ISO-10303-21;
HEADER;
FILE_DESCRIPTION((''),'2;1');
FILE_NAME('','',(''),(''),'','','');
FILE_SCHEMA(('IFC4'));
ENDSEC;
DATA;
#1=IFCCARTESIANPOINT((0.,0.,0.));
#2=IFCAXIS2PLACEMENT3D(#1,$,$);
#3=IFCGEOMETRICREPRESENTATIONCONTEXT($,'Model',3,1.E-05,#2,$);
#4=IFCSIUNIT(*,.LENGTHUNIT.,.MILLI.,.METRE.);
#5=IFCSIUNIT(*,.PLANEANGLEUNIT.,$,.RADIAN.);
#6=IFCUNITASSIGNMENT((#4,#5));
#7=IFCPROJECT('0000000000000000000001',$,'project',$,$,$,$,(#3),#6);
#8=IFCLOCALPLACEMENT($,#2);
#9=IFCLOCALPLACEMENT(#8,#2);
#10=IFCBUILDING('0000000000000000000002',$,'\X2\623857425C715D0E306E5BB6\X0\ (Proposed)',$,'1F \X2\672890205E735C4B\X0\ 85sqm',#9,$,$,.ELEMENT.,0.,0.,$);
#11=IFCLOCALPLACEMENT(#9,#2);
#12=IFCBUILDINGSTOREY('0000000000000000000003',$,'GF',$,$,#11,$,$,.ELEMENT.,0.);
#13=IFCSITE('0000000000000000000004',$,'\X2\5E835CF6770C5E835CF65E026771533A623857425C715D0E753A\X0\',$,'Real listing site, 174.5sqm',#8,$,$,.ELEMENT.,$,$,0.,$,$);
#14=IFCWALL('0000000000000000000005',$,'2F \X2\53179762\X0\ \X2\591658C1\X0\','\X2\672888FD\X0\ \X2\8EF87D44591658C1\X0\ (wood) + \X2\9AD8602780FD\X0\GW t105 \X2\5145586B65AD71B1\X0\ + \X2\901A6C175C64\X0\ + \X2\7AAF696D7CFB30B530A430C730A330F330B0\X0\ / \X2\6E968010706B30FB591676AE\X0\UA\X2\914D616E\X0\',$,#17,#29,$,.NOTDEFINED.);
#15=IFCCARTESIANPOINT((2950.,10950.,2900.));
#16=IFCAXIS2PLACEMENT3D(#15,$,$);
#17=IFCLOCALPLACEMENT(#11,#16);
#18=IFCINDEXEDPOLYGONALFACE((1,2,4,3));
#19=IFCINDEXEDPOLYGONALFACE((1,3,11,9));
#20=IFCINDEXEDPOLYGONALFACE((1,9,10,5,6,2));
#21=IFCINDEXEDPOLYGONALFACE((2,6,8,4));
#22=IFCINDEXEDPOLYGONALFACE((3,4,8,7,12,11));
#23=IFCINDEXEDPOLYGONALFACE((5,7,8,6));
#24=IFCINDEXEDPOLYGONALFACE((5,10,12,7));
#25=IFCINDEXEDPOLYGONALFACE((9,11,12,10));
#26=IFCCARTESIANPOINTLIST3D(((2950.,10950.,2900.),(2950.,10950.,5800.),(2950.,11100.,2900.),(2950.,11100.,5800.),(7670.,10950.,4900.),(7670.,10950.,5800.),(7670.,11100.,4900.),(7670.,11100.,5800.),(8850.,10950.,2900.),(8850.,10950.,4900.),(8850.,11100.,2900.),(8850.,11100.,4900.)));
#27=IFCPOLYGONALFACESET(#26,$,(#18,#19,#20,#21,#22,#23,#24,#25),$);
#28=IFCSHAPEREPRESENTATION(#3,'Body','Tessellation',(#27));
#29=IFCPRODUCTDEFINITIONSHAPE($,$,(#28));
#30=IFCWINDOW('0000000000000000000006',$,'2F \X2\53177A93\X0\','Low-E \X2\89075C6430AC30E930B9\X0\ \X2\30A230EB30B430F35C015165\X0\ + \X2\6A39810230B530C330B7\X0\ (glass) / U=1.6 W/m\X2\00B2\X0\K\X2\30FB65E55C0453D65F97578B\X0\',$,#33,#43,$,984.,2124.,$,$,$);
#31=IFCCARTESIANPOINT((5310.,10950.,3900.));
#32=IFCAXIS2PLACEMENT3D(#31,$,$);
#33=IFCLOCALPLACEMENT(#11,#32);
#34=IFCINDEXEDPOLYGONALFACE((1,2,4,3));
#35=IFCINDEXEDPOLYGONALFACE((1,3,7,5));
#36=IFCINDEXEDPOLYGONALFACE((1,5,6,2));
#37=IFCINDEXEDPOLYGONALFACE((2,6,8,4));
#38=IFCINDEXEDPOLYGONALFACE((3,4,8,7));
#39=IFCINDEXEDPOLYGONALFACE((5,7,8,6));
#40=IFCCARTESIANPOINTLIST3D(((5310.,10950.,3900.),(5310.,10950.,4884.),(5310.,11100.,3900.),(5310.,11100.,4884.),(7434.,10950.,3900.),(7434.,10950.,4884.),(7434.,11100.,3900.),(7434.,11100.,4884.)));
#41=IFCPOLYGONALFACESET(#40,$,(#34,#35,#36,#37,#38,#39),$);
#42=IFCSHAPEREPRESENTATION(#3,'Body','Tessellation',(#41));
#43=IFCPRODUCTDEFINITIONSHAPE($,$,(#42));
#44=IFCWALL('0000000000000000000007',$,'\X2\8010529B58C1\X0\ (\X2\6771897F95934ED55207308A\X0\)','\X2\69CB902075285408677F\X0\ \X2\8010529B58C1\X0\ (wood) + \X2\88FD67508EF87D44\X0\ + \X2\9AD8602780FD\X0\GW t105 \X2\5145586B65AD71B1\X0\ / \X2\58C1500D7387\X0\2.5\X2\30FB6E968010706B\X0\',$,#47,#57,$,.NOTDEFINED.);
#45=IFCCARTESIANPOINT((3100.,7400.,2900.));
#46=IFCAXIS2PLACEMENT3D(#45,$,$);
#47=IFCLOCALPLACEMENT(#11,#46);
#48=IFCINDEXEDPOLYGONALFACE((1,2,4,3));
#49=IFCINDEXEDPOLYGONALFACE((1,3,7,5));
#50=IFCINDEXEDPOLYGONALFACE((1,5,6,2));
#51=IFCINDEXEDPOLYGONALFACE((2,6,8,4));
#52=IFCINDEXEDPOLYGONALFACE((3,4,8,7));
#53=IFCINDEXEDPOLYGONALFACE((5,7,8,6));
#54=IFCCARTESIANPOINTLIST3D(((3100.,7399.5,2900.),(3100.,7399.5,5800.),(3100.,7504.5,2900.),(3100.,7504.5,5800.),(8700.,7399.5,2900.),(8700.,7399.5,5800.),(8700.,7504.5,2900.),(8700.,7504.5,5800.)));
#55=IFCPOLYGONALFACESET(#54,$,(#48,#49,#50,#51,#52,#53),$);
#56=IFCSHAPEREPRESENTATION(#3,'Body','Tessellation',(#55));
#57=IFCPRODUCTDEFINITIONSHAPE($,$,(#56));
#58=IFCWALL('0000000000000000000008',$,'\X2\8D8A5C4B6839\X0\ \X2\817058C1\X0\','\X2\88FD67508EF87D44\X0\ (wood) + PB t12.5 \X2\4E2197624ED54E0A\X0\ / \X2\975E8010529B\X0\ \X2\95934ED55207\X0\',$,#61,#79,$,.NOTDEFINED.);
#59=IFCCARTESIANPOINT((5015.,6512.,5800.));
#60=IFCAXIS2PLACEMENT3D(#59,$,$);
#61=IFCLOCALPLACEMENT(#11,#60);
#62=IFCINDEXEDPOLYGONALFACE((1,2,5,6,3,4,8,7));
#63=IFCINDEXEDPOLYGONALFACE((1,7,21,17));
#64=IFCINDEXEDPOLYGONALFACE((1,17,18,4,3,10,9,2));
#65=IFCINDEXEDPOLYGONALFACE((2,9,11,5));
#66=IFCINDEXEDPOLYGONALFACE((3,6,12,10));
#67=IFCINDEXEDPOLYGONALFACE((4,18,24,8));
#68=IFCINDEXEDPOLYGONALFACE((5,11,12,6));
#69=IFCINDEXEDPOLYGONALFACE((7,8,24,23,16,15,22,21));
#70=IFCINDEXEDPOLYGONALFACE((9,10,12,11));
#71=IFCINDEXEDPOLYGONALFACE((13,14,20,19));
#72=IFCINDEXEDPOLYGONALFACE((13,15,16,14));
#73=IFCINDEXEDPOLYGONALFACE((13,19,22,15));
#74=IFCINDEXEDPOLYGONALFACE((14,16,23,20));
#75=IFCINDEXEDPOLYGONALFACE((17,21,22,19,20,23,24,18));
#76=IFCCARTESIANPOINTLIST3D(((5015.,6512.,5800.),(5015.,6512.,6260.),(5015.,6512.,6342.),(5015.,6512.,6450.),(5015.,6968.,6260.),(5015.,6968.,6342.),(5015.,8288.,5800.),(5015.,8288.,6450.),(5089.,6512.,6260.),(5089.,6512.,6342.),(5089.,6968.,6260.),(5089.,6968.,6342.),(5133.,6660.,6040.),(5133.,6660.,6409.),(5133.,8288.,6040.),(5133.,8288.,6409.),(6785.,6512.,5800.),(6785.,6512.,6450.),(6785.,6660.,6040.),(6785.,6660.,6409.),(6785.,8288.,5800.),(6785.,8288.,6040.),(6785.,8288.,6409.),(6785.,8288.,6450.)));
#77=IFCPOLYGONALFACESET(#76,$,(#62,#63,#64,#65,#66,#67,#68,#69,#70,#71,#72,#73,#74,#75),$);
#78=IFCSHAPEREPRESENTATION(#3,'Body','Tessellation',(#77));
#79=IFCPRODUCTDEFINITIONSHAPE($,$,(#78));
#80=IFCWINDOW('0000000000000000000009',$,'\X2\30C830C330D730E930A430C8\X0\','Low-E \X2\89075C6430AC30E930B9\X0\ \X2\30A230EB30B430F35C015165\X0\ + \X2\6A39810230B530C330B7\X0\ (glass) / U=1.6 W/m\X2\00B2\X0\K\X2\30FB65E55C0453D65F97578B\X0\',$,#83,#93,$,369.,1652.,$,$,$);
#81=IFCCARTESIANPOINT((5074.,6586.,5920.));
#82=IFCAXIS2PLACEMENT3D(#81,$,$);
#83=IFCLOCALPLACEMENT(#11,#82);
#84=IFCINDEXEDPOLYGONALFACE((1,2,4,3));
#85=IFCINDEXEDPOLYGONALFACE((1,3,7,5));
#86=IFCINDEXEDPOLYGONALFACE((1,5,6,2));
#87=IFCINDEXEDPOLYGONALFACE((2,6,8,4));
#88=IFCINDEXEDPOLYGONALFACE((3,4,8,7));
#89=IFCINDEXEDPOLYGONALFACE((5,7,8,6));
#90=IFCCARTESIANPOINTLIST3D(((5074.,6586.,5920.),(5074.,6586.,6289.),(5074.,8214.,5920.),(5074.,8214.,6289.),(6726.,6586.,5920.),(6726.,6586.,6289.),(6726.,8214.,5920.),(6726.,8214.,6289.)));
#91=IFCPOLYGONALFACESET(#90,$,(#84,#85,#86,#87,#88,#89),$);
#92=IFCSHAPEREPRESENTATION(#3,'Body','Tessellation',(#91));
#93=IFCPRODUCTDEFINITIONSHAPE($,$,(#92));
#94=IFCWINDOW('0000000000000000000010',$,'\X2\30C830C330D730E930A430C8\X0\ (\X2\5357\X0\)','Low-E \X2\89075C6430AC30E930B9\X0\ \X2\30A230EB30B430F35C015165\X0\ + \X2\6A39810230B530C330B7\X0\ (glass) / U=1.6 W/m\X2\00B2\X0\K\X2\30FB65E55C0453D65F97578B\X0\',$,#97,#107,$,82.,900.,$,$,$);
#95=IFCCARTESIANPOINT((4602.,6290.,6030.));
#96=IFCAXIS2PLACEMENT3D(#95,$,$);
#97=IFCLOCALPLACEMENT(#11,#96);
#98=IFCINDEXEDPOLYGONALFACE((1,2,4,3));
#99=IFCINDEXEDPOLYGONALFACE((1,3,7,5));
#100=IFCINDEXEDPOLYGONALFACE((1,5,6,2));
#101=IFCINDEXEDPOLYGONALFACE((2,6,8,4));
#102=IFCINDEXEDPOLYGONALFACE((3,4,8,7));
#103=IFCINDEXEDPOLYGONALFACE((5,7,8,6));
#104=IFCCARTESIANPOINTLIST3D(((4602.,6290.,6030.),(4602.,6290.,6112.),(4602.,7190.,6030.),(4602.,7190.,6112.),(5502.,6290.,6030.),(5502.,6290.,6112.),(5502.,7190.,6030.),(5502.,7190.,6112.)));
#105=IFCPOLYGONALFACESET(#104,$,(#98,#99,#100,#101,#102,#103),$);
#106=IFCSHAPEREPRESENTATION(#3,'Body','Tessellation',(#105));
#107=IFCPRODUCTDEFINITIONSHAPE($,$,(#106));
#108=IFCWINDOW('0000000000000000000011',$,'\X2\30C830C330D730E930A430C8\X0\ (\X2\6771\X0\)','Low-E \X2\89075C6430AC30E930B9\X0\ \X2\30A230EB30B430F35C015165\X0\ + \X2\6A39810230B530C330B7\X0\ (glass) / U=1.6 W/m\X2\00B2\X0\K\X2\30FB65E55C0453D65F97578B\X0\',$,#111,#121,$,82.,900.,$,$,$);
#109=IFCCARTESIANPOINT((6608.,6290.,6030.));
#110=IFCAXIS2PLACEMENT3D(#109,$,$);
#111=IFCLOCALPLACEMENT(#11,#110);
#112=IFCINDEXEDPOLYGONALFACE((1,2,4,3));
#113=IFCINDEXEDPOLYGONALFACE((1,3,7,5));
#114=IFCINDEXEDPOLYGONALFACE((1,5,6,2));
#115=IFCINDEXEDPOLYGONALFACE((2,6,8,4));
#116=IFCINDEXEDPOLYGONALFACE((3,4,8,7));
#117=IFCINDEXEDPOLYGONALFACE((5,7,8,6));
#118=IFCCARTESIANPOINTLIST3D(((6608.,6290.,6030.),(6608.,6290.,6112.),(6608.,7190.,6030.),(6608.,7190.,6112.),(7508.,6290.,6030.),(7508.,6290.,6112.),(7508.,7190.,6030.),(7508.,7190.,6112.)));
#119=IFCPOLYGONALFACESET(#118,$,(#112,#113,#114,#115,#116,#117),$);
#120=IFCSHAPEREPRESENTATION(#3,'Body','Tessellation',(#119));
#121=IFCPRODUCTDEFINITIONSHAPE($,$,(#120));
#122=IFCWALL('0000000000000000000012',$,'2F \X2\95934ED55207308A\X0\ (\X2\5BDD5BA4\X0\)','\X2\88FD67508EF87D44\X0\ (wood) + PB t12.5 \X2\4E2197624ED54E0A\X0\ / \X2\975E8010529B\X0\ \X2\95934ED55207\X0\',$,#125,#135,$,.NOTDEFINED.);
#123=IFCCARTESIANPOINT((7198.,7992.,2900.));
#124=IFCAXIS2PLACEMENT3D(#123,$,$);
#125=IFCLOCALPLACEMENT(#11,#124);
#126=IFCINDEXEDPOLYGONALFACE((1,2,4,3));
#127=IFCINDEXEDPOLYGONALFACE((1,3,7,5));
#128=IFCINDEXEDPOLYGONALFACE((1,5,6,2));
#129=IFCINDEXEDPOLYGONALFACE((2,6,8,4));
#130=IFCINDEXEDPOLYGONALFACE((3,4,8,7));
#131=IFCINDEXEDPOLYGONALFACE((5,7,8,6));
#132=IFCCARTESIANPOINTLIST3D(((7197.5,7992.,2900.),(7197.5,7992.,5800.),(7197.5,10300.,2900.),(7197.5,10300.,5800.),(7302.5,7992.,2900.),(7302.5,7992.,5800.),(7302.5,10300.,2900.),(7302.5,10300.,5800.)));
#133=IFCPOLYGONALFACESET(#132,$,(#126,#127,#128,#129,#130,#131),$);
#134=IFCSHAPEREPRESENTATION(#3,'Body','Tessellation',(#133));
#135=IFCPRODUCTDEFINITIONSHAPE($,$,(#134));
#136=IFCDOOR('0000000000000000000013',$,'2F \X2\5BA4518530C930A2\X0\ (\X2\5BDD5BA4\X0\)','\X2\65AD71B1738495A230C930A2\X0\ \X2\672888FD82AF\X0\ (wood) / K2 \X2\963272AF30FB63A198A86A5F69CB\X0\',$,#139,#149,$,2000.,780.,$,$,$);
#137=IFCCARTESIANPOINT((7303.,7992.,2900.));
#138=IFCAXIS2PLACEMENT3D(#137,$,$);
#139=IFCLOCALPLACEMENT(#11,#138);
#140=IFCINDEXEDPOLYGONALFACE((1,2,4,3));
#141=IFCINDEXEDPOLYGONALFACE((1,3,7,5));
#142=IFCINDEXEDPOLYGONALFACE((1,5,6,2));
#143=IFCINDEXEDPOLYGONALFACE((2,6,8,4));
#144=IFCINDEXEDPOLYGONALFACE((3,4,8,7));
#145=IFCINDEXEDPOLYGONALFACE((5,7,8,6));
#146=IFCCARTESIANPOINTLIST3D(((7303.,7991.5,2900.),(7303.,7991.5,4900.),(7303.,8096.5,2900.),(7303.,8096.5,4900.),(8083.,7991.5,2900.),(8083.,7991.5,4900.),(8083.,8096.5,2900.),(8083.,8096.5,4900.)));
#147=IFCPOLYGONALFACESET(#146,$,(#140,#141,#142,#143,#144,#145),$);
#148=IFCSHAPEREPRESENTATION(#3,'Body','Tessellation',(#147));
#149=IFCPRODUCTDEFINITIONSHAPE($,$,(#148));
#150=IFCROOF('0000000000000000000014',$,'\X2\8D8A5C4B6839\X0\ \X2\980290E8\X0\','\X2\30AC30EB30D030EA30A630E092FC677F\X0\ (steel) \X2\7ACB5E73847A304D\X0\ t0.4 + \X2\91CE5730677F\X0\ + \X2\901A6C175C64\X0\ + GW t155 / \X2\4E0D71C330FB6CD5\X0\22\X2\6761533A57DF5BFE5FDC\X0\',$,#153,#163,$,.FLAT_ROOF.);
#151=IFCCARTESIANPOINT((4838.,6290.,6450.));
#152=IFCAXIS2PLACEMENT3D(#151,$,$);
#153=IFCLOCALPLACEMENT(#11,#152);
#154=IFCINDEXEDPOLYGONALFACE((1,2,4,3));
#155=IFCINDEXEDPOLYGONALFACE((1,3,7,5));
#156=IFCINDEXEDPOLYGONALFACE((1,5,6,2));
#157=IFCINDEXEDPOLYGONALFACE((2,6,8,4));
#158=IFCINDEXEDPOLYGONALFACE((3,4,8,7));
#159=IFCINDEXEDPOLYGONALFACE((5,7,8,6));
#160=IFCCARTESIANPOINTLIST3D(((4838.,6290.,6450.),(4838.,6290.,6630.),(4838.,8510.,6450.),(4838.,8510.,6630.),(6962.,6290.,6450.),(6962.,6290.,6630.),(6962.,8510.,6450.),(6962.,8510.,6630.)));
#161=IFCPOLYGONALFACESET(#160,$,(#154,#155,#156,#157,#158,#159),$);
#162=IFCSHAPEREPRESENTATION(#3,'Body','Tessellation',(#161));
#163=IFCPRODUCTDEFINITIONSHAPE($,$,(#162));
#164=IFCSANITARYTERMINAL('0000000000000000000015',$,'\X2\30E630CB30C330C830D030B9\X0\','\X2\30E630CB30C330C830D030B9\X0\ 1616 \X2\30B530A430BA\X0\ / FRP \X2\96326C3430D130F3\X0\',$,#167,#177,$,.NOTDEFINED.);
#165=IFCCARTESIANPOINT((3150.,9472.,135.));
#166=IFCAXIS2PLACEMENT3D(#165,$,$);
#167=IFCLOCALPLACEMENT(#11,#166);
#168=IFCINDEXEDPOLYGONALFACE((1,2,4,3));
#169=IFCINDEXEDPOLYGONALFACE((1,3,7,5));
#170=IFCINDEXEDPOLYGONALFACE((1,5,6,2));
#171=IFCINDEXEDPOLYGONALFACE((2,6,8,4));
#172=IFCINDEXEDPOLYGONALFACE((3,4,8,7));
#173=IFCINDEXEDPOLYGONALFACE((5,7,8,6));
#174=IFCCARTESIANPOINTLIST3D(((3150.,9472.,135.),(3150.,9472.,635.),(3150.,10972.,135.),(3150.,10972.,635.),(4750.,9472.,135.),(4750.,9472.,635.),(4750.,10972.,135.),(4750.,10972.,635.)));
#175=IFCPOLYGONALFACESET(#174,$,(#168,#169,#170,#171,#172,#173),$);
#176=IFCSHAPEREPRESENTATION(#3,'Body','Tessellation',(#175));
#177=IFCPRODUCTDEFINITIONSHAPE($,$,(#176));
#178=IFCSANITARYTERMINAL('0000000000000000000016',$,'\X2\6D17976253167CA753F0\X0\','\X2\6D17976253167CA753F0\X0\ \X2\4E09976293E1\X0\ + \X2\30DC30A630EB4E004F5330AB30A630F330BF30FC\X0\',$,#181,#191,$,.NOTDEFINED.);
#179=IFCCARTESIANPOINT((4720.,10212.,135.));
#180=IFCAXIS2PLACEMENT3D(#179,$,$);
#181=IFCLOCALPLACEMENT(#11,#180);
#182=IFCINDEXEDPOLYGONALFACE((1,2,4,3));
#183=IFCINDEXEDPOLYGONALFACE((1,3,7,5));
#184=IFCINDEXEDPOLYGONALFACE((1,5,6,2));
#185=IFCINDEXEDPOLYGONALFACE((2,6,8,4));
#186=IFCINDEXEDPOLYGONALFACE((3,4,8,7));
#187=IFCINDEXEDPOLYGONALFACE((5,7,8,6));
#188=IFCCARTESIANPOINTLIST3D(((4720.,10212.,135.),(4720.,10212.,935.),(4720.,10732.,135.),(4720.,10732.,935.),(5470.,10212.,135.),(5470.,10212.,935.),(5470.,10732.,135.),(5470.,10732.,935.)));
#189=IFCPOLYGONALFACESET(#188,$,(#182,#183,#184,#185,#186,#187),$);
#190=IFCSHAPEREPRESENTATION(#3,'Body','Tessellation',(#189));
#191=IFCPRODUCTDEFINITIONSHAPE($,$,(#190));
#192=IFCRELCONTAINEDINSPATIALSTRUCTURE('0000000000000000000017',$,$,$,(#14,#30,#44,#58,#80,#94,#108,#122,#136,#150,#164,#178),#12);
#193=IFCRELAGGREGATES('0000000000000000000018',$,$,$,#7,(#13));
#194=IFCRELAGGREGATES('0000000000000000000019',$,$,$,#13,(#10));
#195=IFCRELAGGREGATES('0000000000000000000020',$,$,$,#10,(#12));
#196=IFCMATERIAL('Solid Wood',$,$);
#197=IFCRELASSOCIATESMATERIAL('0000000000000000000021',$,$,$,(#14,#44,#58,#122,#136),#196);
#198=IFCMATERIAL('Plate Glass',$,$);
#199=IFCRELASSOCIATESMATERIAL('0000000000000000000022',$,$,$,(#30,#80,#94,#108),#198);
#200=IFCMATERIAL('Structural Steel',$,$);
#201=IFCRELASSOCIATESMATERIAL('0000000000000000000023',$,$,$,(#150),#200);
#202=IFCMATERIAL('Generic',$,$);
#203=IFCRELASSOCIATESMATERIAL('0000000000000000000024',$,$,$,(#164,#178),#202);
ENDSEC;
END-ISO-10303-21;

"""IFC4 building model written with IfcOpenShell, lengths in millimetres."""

from ifc_helpers import new_model, si_unit, frame, frame_2d, origin, place, context, project, spatial, rectangle, extrude, material, element, fill, save


model = new_model("IFC4")

# Units and contexts
model_context = context("Model", 3, precision=1e-05, world=origin())
ifc_project = project(units=[si_unit("LENGTHUNIT", "METRE", prefix="MILLI"), si_unit("PLANEANGLEUNIT", "RADIAN")], contexts=[model_context])

# Site, building, storey
site_placement = place(None, origin())
site = spatial("IfcSite", under=ifc_project, at=site_placement, Name="広島県広島市東区戸坂山崎町", ObjectType="Real listing site, 174.5sqm", CompositionType="ELEMENT", RefElevation=0.0)
building_placement = place(site_placement, origin())
building = spatial("IfcBuilding", under=site, at=building_placement, Name="戸坂山崎の家 (Proposed)", ObjectType="1F 木造平屋 85sqm", CompositionType="ELEMENT", ElevationOfRefHeight=0.0, ElevationOfTerrain=0.0)
storey_placement = place(building_placement, origin())
storey = spatial("IfcBuildingStorey", under=building, at=storey_placement, Name="GF", CompositionType="ELEMENT", Elevation=0.0)

# Wall, opening, window
ifc_material_1 = material(Name="Solid Wood")
wall_1_placement = place(storey_placement, frame((2950.0, 10950.0, 2900.0)))
wall_1 = element("IfcWall", 1, at=wall_1_placement, inside=storey, material=ifc_material_1, Name="2F 北面 外壁", Description="木製 軸組外壁 (wood) + 高性能GW t105 充填断熱 + 通気層 + 窯業系サイディング / 準耐火・外皮UA配慮", PredefinedType="NOTDEFINED", context=model_context, shape_type="SweptSolid", body=[
    extrude(rectangle(XDim=5900.0, YDim=150.0, at=frame_2d((2950.0, 75.0))), frame((2950.0, 10950.0, 2900.0)), (0.0, 0.0, 1.0), 2900.0),
])
opening_1_placement = place(storey_placement, frame((5310.0, 10950.0, 3900.0)))
opening_1 = element("IfcOpeningElement", 2, at=opening_1_placement, cuts=wall_1, PredefinedType="NOTDEFINED", context=model_context, shape_type="SweptSolid", body=[
    extrude(rectangle(XDim=2124.0, YDim=150.0, at=frame_2d((1062.0, 75.0))), frame((5310.0, 10950.0, 3900.0)), (0.0, 0.0, 1.0), 984.0),
])
ifc_material_2 = material(Name="Plate Glass")
window_1_placement = place(storey_placement, frame((5310.0, 10950.0, 3900.0)))
window_1 = element("IfcWindow", 3, at=window_1_placement, inside=storey, material=ifc_material_2, Name="2F 北窓", Description="Low-E 複層ガラス アルゴン封入 + 樹脂サッシ (glass) / U=1.6 W/m²K・日射取得型", OverallHeight=984.0, OverallWidth=2124.0, context=model_context, shape_type="SweptSolid", body=[
    extrude(rectangle(XDim=2124.0, YDim=150.0, at=frame_2d((1062.0, 75.0))), frame((5310.0, 10950.0, 3900.0)), (0.0, 0.0, 1.0), 984.0),
])
fill(opening_1, window_1)

# Wall
wall_2_placement = place(storey_placement, frame((3100.0, 7400.0, 2900.0)))
element("IfcWall", 4, at=wall_2_placement, inside=storey, material=ifc_material_1, Name="耐力壁 (東西間仕切り)", Description="構造用合板 耐力壁 (wood) + 製材軸組 + 高性能GW t105 充填断熱 / 壁倍率2.5・準耐火", PredefinedType="NOTDEFINED", context=model_context, shape_type="SweptSolid", body=[
    extrude(rectangle(XDim=5600.0, YDim=105.0, at=frame_2d((2800.0, 52.0))), frame((3100.0, 7400.0, 2900.0)), (0.0, 0.0, 1.0), 2900.0),
])

# Wall, openings, windows
wall_3_placement = place(storey_placement, frame((5015.0, 6512.0, 5800.0)))
wall_3 = element("IfcWall", 5, at=wall_3_placement, inside=storey, material=ifc_material_1, Name="越屋根 腰壁", Description="製材軸組 (wood) + PB t12.5 両面仕上 / 非耐力 間仕切", PredefinedType="NOTDEFINED", context=model_context, shape_type="SweptSolid", body=[
    extrude(rectangle(XDim=1770.0, YDim=1776.0, at=frame_2d((885.0, 888.0))), frame((5015.0, 6512.0, 5800.0)), (0.0, 0.0, 1.0), 650.0),
])
opening_2_placement = place(storey_placement, frame((5074.0, 6586.0, 5920.0)))
opening_2 = element("IfcOpeningElement", 6, at=opening_2_placement, cuts=wall_3, PredefinedType="NOTDEFINED", context=model_context, shape_type="SweptSolid", body=[
    extrude(rectangle(XDim=1652.0, YDim=1628.0, at=frame_2d((826.0, 814.0))), frame((5074.0, 6586.0, 5920.0)), (0.0, 0.0, 1.0), 369.0),
])
opening_3_placement = place(storey_placement, frame((4602.0, 6290.0, 6030.0)))
opening_3 = element("IfcOpeningElement", 7, at=opening_3_placement, cuts=wall_3, PredefinedType="NOTDEFINED", context=model_context, shape_type="SweptSolid", body=[
    extrude(rectangle(XDim=900.0, YDim=900.0, at=frame_2d((450.0, 450.0))), frame((4602.0, 6290.0, 6030.0)), (0.0, 0.0, 1.0), 82.0),
])
opening_4_placement = place(storey_placement, frame((6608.0, 6290.0, 6030.0)))
opening_4 = element("IfcOpeningElement", 8, at=opening_4_placement, cuts=wall_3, PredefinedType="NOTDEFINED", context=model_context, shape_type="SweptSolid", body=[
    extrude(rectangle(XDim=900.0, YDim=900.0, at=frame_2d((450.0, 450.0))), frame((6608.0, 6290.0, 6030.0)), (0.0, 0.0, 1.0), 82.0),
])
window_2_placement = place(storey_placement, frame((5074.0, 6586.0, 5920.0)))
window_2 = element("IfcWindow", 9, at=window_2_placement, inside=storey, material=ifc_material_2, Name="トップライト", Description="Low-E 複層ガラス アルゴン封入 + 樹脂サッシ (glass) / U=1.6 W/m²K・日射取得型", OverallHeight=369.0, OverallWidth=1652.0, context=model_context, shape_type="SweptSolid", body=[
    extrude(rectangle(XDim=1652.0, YDim=1628.0, at=frame_2d((826.0, 814.0))), frame((5074.0, 6586.0, 5920.0)), (0.0, 0.0, 1.0), 369.0),
])
fill(opening_2, window_2)
window_3_placement = place(storey_placement, frame((4602.0, 6290.0, 6030.0)))
window_3 = element("IfcWindow", 10, at=window_3_placement, inside=storey, material=ifc_material_2, Name="トップライト (南)", Description="Low-E 複層ガラス アルゴン封入 + 樹脂サッシ (glass) / U=1.6 W/m²K・日射取得型", OverallHeight=82.0, OverallWidth=900.0, context=model_context, shape_type="SweptSolid", body=[
    extrude(rectangle(XDim=900.0, YDim=900.0, at=frame_2d((450.0, 450.0))), frame((4602.0, 6290.0, 6030.0)), (0.0, 0.0, 1.0), 82.0),
])
fill(opening_3, window_3)
window_4_placement = place(storey_placement, frame((6608.0, 6290.0, 6030.0)))
window_4 = element("IfcWindow", 11, at=window_4_placement, inside=storey, material=ifc_material_2, Name="トップライト (東)", Description="Low-E 複層ガラス アルゴン封入 + 樹脂サッシ (glass) / U=1.6 W/m²K・日射取得型", OverallHeight=82.0, OverallWidth=900.0, context=model_context, shape_type="SweptSolid", body=[
    extrude(rectangle(XDim=900.0, YDim=900.0, at=frame_2d((450.0, 450.0))), frame((6608.0, 6290.0, 6030.0)), (0.0, 0.0, 1.0), 82.0),
])
fill(opening_4, window_4)

# Wall
wall_4_placement = place(storey_placement, frame((7198.0, 7992.0, 2900.0)))
element("IfcWall", 12, at=wall_4_placement, inside=storey, material=ifc_material_1, Name="2F 間仕切り (寝室)", Description="製材軸組 (wood) + PB t12.5 両面仕上 / 非耐力 間仕切", PredefinedType="NOTDEFINED", context=model_context, shape_type="SweptSolid", body=[
    extrude(rectangle(XDim=105.0, YDim=2308.0, at=frame_2d((52.0, 1154.0))), frame((7198.0, 7992.0, 2900.0)), (0.0, 0.0, 1.0), 2900.0),
])

# Door
door_placement = place(storey_placement, frame((7303.0, 7992.0, 2900.0)))
element("IfcDoor", 13, at=door_placement, inside=storey, material=ifc_material_1, Name="2F 室内ドア (寝室)", Description="断熱玄関ドア 木製芯 (wood) / K2 防犯・採風機構", OverallHeight=2000.0, OverallWidth=780.0, context=model_context, shape_type="SweptSolid", body=[
    extrude(rectangle(XDim=780.0, YDim=105.0, at=frame_2d((390.0, 52.0))), frame((7303.0, 7992.0, 2900.0)), (0.0, 0.0, 1.0), 2000.0),
])

# Roof
ifc_material_3 = material(Name="Structural Steel")
roof_placement = place(storey_placement, frame((4838.0, 6290.0, 6450.0)))
element("IfcRoof", 14, at=roof_placement, inside=storey, material=ifc_material_3, Name="越屋根 頂部", Description="ガルバリウム鋼板 (steel) 立平葺き t0.4 + 野地板 + 通気層 + GW t155 / 不燃・法22条区域対応", PredefinedType="FLAT_ROOF", context=model_context, shape_type="SweptSolid", body=[
    extrude(rectangle(XDim=2124.0, YDim=2220.0, at=frame_2d((1062.0, 1110.0))), frame((4838.0, 6290.0, 6450.0)), (0.0, 0.0, 1.0), 180.0),
])

# Sanitary terminals
ifc_material_4 = material(Name="Generic")
sanitary_terminal_1_placement = place(storey_placement, frame((3150.0, 9472.0, 135.0)))
element("IfcSanitaryTerminal", 15, at=sanitary_terminal_1_placement, inside=storey, material=ifc_material_4, Name="ユニットバス", Description="ユニットバス 1616 サイズ / FRP 防水パン", PredefinedType="NOTDEFINED", context=model_context, shape_type="SweptSolid", body=[
    extrude(rectangle(XDim=1600.0, YDim=1500.0, at=frame_2d((800.0, 750.0))), frame((3150.0, 9472.0, 135.0)), (0.0, 0.0, 1.0), 500.0),
])
sanitary_terminal_2_placement = place(storey_placement, frame((4720.0, 10212.0, 135.0)))
element("IfcSanitaryTerminal", 16, at=sanitary_terminal_2_placement, inside=storey, material=ifc_material_4, Name="洗面化粧台", Description="洗面化粧台 三面鏡 + ボウル一体カウンター", PredefinedType="NOTDEFINED", context=model_context, shape_type="SweptSolid", body=[
    extrude(rectangle(XDim=750.0, YDim=520.0, at=frame_2d((375.0, 260.0))), frame((4720.0, 10212.0, 135.0)), (0.0, 0.0, 1.0), 800.0),
])

save(model, "model.ifc")
